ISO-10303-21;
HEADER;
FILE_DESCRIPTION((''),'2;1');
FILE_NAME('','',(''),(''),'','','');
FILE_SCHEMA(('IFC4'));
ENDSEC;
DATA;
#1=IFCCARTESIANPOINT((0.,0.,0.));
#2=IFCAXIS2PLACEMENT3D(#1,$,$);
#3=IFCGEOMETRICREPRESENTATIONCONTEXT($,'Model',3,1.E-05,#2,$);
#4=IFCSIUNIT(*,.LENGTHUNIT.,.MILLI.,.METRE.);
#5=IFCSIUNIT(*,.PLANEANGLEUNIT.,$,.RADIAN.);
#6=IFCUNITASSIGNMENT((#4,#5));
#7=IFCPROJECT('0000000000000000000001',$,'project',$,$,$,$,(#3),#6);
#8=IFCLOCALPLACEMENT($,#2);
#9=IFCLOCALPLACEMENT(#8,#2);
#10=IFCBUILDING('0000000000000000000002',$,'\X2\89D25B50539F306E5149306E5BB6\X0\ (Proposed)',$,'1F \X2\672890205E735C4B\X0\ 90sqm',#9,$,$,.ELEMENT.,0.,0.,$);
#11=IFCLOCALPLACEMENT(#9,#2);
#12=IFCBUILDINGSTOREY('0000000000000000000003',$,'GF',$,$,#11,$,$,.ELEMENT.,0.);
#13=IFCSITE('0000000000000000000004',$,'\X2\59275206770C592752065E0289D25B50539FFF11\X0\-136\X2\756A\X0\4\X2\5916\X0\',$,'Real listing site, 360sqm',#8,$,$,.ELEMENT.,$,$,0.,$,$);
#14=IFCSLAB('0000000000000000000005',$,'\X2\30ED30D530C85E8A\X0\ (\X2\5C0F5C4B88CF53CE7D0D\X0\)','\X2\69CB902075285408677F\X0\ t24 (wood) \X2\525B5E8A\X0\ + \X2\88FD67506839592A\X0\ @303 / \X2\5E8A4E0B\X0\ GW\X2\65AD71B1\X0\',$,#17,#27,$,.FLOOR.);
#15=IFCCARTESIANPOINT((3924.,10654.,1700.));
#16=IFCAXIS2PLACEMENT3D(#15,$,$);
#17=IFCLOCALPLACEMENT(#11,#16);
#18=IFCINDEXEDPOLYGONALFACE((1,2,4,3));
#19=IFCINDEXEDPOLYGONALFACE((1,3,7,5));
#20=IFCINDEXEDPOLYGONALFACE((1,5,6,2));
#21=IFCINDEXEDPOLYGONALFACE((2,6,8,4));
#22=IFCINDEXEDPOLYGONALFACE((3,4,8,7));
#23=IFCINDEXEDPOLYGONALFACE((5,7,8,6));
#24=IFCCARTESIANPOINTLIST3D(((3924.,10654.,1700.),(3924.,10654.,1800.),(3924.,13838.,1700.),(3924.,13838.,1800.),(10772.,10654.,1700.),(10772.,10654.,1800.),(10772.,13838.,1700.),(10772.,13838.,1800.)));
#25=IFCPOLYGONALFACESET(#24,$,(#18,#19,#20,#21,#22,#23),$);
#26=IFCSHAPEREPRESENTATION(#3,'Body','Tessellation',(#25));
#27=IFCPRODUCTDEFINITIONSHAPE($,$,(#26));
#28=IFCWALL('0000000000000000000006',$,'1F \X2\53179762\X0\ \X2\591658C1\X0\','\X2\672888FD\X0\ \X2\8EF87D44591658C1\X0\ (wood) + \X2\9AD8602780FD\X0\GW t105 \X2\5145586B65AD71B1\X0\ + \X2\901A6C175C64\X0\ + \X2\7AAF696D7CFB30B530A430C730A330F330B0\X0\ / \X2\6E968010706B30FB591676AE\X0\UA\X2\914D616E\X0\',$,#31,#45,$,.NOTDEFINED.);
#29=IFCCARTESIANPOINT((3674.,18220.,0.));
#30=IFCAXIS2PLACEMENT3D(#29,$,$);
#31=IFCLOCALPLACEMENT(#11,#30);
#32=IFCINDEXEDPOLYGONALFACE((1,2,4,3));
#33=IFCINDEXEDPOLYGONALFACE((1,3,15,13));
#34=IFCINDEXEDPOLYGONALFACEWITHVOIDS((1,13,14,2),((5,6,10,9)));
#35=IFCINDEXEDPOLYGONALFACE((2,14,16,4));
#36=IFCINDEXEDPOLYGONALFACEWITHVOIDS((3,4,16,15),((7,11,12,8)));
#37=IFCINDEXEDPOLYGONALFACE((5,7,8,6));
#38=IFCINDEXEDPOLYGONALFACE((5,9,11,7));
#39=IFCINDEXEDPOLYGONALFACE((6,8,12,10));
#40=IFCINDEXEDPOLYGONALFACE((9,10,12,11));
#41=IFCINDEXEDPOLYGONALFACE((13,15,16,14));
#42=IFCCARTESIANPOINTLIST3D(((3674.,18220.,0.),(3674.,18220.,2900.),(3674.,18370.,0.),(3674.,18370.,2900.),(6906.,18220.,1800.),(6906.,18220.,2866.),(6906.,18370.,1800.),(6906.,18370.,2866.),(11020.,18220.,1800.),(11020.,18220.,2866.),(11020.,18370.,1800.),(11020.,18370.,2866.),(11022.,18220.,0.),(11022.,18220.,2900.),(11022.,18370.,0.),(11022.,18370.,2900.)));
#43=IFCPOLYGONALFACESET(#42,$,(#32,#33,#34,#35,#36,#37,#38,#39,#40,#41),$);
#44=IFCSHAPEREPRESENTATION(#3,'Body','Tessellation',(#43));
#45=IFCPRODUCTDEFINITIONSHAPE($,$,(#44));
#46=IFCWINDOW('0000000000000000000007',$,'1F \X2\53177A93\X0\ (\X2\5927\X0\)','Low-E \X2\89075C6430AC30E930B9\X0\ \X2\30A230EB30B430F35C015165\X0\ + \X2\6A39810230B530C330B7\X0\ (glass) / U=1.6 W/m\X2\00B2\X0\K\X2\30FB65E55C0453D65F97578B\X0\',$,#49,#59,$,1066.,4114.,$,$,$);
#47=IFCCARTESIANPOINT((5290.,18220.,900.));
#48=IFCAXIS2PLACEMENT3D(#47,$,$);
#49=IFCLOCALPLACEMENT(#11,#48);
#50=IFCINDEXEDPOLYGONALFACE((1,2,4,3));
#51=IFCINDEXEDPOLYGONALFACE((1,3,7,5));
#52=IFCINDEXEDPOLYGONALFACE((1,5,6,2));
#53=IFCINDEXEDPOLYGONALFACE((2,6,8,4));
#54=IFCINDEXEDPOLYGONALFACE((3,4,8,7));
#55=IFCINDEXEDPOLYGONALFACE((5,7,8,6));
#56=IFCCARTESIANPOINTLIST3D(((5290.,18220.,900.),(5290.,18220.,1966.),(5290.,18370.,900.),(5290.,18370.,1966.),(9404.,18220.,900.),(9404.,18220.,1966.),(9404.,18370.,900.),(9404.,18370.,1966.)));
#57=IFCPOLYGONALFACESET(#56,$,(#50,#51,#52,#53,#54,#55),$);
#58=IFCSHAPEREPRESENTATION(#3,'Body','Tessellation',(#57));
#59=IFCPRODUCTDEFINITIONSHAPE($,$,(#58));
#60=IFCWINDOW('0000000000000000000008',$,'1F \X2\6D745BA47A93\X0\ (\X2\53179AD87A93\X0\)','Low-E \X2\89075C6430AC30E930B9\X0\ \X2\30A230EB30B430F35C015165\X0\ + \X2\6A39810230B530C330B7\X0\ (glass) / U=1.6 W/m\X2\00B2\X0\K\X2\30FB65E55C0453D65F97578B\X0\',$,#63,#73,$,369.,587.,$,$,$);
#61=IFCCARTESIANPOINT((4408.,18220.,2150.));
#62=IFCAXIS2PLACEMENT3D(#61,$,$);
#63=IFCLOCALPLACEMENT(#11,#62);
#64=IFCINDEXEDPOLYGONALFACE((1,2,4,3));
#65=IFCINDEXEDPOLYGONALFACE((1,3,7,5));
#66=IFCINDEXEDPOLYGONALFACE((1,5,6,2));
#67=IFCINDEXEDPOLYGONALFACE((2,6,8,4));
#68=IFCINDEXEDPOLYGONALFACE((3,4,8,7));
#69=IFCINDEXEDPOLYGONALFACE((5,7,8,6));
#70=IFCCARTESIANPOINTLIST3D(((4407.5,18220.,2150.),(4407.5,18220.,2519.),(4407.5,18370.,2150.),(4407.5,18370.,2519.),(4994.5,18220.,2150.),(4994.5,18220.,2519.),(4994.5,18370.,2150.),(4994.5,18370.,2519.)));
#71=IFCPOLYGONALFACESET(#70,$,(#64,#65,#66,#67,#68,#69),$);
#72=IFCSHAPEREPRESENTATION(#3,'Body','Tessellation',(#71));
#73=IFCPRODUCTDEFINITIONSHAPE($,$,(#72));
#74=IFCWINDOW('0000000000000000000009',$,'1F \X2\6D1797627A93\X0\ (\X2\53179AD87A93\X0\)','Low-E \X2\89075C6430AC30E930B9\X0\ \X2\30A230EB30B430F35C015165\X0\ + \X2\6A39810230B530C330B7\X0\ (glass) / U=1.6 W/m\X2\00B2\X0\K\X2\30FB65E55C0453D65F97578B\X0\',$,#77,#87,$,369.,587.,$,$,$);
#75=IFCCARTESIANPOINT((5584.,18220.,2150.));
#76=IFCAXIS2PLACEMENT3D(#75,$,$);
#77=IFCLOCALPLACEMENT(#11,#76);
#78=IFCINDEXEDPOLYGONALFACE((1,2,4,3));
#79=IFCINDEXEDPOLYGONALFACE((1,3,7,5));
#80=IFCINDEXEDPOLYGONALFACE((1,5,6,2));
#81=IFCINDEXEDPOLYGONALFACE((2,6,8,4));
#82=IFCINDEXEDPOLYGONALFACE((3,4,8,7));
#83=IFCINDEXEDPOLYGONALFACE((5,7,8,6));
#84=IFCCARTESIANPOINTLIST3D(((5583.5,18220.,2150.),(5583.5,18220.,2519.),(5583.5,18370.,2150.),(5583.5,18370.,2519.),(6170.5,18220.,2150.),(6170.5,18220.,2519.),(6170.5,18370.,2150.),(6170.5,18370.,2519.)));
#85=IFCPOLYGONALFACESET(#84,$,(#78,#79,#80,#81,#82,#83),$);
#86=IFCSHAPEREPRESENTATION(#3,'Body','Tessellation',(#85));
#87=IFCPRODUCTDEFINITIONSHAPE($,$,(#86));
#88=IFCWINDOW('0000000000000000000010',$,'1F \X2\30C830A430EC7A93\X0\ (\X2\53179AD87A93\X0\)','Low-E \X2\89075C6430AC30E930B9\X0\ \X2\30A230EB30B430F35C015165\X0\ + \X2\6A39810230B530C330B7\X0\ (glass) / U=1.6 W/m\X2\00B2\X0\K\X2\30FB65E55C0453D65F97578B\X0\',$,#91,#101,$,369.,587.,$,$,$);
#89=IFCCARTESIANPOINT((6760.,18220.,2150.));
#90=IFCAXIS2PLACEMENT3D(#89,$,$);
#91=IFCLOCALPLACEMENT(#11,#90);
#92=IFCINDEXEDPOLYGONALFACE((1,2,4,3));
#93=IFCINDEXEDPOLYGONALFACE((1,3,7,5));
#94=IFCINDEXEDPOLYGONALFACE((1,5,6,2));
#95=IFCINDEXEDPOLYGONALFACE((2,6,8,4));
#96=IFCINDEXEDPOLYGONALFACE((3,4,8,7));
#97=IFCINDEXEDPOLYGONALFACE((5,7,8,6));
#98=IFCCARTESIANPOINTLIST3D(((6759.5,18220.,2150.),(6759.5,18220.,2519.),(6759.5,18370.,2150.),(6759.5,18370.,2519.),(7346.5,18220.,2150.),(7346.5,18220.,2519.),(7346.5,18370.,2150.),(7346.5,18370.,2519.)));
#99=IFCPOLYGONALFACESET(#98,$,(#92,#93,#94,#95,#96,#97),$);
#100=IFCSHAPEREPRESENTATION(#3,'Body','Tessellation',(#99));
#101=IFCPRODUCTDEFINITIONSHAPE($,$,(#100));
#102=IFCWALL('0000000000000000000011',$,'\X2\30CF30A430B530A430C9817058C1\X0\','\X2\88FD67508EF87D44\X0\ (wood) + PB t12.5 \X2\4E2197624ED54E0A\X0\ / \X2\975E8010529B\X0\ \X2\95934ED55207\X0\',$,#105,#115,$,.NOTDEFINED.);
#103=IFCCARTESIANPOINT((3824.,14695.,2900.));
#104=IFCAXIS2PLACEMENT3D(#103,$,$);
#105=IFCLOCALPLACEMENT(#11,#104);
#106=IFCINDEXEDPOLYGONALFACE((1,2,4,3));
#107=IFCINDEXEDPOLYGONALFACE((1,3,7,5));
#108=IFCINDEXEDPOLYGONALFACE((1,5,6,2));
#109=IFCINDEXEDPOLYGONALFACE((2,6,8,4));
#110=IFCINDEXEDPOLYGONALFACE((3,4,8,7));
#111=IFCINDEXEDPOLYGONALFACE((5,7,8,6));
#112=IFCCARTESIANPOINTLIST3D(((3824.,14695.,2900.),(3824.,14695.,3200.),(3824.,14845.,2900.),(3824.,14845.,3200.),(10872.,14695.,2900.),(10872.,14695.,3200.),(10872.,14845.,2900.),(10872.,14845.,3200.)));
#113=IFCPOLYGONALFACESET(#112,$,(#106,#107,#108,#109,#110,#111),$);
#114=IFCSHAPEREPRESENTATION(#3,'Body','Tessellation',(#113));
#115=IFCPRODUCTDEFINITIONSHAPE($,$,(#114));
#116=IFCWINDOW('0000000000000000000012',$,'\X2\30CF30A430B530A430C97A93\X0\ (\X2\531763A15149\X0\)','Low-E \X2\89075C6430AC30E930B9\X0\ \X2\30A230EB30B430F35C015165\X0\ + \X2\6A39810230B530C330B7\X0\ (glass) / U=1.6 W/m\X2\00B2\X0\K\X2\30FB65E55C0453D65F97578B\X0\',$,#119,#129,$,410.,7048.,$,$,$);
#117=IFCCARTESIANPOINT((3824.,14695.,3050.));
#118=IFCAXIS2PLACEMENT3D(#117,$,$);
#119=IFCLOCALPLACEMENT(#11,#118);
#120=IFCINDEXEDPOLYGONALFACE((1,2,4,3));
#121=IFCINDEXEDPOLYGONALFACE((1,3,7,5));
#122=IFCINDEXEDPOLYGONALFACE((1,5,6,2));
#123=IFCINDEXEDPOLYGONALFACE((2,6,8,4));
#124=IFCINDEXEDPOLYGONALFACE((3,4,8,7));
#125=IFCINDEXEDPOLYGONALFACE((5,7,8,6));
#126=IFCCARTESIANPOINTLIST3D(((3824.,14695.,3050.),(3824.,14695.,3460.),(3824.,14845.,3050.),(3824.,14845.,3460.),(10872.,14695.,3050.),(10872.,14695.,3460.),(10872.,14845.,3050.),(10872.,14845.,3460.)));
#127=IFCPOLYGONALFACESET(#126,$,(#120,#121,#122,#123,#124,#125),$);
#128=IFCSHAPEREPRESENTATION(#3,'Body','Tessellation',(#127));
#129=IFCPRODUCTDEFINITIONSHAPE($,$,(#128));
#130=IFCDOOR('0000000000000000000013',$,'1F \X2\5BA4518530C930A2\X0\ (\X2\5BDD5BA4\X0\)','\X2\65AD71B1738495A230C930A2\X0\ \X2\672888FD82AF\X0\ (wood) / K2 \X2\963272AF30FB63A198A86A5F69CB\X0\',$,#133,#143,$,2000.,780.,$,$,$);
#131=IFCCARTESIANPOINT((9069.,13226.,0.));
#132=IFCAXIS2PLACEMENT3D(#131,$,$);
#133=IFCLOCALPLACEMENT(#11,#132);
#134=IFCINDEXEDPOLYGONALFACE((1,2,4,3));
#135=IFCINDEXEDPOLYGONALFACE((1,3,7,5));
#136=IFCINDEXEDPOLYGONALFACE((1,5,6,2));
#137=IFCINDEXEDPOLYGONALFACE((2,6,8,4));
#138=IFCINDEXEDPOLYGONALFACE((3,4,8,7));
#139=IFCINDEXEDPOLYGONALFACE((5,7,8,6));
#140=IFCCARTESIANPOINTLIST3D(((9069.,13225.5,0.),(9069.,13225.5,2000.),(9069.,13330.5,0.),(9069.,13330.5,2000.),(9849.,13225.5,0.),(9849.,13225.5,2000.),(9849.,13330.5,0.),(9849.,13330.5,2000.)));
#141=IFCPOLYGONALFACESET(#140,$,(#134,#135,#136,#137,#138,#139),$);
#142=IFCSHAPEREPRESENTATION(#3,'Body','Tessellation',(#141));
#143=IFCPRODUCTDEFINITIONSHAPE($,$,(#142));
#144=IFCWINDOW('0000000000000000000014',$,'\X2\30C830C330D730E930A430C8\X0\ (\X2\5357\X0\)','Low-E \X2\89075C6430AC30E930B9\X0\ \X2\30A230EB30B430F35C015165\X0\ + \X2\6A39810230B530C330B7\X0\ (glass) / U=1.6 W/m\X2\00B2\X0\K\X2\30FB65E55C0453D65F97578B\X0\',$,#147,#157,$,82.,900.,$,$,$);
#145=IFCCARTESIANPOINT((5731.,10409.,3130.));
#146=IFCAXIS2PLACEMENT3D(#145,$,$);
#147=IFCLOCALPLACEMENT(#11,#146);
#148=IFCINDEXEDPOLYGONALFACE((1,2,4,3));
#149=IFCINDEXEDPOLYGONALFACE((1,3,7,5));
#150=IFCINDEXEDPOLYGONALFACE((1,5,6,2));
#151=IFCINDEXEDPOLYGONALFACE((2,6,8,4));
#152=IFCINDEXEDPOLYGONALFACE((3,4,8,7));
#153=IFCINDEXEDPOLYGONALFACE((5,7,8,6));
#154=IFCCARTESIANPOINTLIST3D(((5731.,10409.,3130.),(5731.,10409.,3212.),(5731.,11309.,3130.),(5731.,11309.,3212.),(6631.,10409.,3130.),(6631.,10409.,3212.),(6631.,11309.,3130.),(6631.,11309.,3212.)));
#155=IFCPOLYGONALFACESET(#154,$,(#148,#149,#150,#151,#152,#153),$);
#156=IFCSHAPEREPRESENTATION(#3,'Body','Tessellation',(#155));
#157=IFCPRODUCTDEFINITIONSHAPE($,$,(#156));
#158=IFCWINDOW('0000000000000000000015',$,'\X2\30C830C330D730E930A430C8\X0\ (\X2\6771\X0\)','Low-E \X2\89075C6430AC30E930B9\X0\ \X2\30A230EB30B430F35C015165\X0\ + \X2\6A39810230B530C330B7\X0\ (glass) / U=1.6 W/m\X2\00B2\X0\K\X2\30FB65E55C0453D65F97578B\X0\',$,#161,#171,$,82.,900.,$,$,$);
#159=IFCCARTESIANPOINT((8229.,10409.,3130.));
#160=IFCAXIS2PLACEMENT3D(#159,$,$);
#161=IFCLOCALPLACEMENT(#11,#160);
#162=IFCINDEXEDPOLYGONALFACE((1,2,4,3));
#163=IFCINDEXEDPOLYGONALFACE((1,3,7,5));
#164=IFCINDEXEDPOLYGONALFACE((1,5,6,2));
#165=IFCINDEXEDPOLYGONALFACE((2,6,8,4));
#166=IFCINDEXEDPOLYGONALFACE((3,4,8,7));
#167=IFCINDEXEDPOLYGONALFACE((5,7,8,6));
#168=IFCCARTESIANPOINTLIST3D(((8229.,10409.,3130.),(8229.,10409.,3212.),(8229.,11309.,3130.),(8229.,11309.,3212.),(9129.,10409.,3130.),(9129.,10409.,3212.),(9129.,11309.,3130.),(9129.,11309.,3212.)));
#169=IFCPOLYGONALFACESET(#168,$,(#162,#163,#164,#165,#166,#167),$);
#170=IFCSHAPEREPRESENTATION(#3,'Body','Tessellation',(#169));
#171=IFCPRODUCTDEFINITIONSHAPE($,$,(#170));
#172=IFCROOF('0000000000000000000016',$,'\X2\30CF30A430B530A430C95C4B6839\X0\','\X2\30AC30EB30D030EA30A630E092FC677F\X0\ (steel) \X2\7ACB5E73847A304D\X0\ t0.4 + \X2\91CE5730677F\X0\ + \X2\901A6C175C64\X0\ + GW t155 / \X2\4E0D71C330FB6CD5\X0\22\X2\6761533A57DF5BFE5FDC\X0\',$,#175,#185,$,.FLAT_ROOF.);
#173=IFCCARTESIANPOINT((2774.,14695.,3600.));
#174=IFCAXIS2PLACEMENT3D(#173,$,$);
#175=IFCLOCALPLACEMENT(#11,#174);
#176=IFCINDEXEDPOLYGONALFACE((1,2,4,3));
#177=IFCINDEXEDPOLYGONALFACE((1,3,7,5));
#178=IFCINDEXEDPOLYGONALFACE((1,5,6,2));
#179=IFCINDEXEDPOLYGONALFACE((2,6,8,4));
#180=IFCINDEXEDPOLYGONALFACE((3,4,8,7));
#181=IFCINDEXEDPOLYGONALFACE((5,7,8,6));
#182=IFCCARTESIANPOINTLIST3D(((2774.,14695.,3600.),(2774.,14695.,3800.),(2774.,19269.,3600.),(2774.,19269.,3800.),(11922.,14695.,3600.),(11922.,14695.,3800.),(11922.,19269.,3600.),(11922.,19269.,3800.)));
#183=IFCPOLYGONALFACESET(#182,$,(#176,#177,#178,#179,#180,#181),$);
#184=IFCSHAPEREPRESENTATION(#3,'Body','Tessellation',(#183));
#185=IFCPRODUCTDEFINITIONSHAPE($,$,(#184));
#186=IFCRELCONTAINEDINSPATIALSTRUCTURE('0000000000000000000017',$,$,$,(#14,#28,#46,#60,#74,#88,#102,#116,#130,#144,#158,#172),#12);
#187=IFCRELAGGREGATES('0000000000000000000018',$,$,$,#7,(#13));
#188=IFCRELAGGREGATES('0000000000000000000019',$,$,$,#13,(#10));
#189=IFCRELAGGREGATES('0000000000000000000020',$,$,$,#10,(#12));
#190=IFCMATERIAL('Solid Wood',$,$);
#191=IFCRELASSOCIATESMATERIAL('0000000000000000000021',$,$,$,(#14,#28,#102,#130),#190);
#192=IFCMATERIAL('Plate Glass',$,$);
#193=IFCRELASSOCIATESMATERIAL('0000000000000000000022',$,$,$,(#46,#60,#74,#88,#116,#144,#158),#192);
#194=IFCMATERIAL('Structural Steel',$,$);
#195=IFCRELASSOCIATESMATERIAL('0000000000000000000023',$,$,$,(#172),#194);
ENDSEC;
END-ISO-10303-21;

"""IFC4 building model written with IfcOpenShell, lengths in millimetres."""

from ifc_helpers import new_model, si_unit, frame, frame_2d, origin, place, context, project, spatial, rectangle, extrude, material, element, fill, save


model = new_model("IFC4")

# Units and contexts
model_context = context("Model", 3, precision=1e-05, world=origin())
ifc_project = project(units=[si_unit("LENGTHUNIT", "METRE", prefix="MILLI"), si_unit("PLANEANGLEUNIT", "RADIAN")], contexts=[model_context])

# Site, building, storey
site_placement = place(None, origin())
site = spatial("IfcSite", under=ifc_project, at=site_placement, Name="大分県大分市角子原１-136番4外", ObjectType="Real listing site, 360sqm", CompositionType="ELEMENT", RefElevation=0.0)
building_placement = place(site_placement, origin())
building = spatial("IfcBuilding", under=site, at=building_placement, Name="角子原の光の家 (Proposed)", ObjectType="1F 木造平屋 90sqm", CompositionType="ELEMENT", ElevationOfRefHeight=0.0, ElevationOfTerrain=0.0)
storey_placement = place(building_placement, origin())
storey = spatial("IfcBuildingStorey", under=building, at=storey_placement, Name="GF", CompositionType="ELEMENT", Elevation=0.0)

# Slab
ifc_material_1 = material(Name="Solid Wood")
slab_placement = place(storey_placement, frame((3924.0, 10654.0, 1700.0)))
element("IfcSlab", 1, at=slab_placement, inside=storey, material=ifc_material_1, Name="ロフト床 (小屋裏収納)", Description="構造用合板 t24 (wood) 剛床 + 製材根太 @303 / 床下 GW断熱", PredefinedType="FLOOR", context=model_context, shape_type="SweptSolid", body=[
    extrude(rectangle(XDim=6848.0, YDim=3184.0, at=frame_2d((3424.0, 1592.0))), frame((3924.0, 10654.0, 1700.0)), (0.0, 0.0, 1.0), 100.0),
])

# Wall, openings, windows
wall_1_placement = place(storey_placement, frame((3674.0, 18220.0, 0.0)))
wall_1 = element("IfcWall", 2, at=wall_1_placement, inside=storey, material=ifc_material_1, Name="1F 北面 外壁", Description="木製 軸組外壁 (wood) + 高性能GW t105 充填断熱 + 通気層 + 窯業系サイディング / 準耐火・外皮UA配慮", PredefinedType="NOTDEFINED", context=model_context, shape_type="SweptSolid", body=[
    extrude(rectangle(XDim=7348.0, YDim=150.0, at=frame_2d((3674.0, 75.0))), frame((3674.0, 18220.0, 0.0)), (0.0, 0.0, 1.0), 2900.0),
])
opening_1_placement = place(storey_placement, frame((5290.0, 18220.0, 900.0)))
opening_1 = element("IfcOpeningElement", 3, at=opening_1_placement, cuts=wall_1, PredefinedType="NOTDEFINED", context=model_context, shape_type="SweptSolid", body=[
    extrude(rectangle(XDim=4114.0, YDim=150.0, at=frame_2d((2057.0, 75.0))), frame((5290.0, 18220.0, 900.0)), (0.0, 0.0, 1.0), 1066.0),
])
opening_2_placement = place(storey_placement, frame((4408.0, 18220.0, 2150.0)))
opening_2 = element("IfcOpeningElement", 4, at=opening_2_placement, cuts=wall_1, PredefinedType="NOTDEFINED", context=model_context, shape_type="SweptSolid", body=[
    extrude(rectangle(XDim=587.0, YDim=150.0, at=frame_2d((293.0, 75.0))), frame((4408.0, 18220.0, 2150.0)), (0.0, 0.0, 1.0), 369.0),
])
opening_3_placement = place(storey_placement, frame((5584.0, 18220.0, 2150.0)))
opening_3 = element("IfcOpeningElement", 5, at=opening_3_placement, cuts=wall_1, PredefinedType="NOTDEFINED", context=model_context, shape_type="SweptSolid", body=[
    extrude(rectangle(XDim=587.0, YDim=150.0, at=frame_2d((293.0, 75.0))), frame((5584.0, 18220.0, 2150.0)), (0.0, 0.0, 1.0), 369.0),
])
opening_4_placement = place(storey_placement, frame((6760.0, 18220.0, 2150.0)))
opening_4 = element("IfcOpeningElement", 6, at=opening_4_placement, cuts=wall_1, PredefinedType="NOTDEFINED", context=model_context, shape_type="SweptSolid", body=[
    extrude(rectangle(XDim=587.0, YDim=150.0, at=frame_2d((293.0, 75.0))), frame((6760.0, 18220.0, 2150.0)), (0.0, 0.0, 1.0), 369.0),
])
ifc_material_2 = material(Name="Plate Glass")
window_1_placement = place(storey_placement, frame((5290.0, 18220.0, 900.0)))
window_1 = element("IfcWindow", 7, at=window_1_placement, inside=storey, material=ifc_material_2, Name="1F 北窓 (大)", Description="Low-E 複層ガラス アルゴン封入 + 樹脂サッシ (glass) / U=1.6 W/m²K・日射取得型", OverallHeight=1066.0, OverallWidth=4114.0, context=model_context, shape_type="SweptSolid", body=[
    extrude(rectangle(XDim=4114.0, YDim=150.0, at=frame_2d((2057.0, 75.0))), frame((5290.0, 18220.0, 900.0)), (0.0, 0.0, 1.0), 1066.0),
])
fill(opening_1, window_1)
window_2_placement = place(storey_placement, frame((4408.0, 18220.0, 2150.0)))
window_2 = element("IfcWindow", 8, at=window_2_placement, inside=storey, material=ifc_material_2, Name="1F 浴室窓 (北高窓)", Description="Low-E 複層ガラス アルゴン封入 + 樹脂サッシ (glass) / U=1.6 W/m²K・日射取得型", OverallHeight=369.0, OverallWidth=587.0, context=model_context, shape_type="SweptSolid", body=[
    extrude(rectangle(XDim=587.0, YDim=150.0, at=frame_2d((293.0, 75.0))), frame((4408.0, 18220.0, 2150.0)), (0.0, 0.0, 1.0), 369.0),
])
fill(opening_2, window_2)
window_3_placement = place(storey_placement, frame((5584.0, 18220.0, 2150.0)))
window_3 = element("IfcWindow", 9, at=window_3_placement, inside=storey, material=ifc_material_2, Name="1F 洗面窓 (北高窓)", Description="Low-E 複層ガラス アルゴン封入 + 樹脂サッシ (glass) / U=1.6 W/m²K・日射取得型", OverallHeight=369.0, OverallWidth=587.0, context=model_context, shape_type="SweptSolid", body=[
    extrude(rectangle(XDim=587.0, YDim=150.0, at=frame_2d((293.0, 75.0))), frame((5584.0, 18220.0, 2150.0)), (0.0, 0.0, 1.0), 369.0),
])
fill(opening_3, window_3)
window_4_placement = place(storey_placement, frame((6760.0, 18220.0, 2150.0)))
window_4 = element("IfcWindow", 10, at=window_4_placement, inside=storey, material=ifc_material_2, Name="1F トイレ窓 (北高窓)", Description="Low-E 複層ガラス アルゴン封入 + 樹脂サッシ (glass) / U=1.6 W/m²K・日射取得型", OverallHeight=369.0, OverallWidth=587.0, context=model_context, shape_type="SweptSolid", body=[
    extrude(rectangle(XDim=587.0, YDim=150.0, at=frame_2d((293.0, 75.0))), frame((6760.0, 18220.0, 2150.0)), (0.0, 0.0, 1.0), 369.0),
])
fill(opening_4, window_4)

# Wall, opening, window
wall_2_placement = place(storey_placement, frame((3824.0, 14695.0, 2900.0)))
wall_2 = element("IfcWall", 11, at=wall_2_placement, inside=storey, material=ifc_material_1, Name="ハイサイド腰壁", Description="製材軸組 (wood) + PB t12.5 両面仕上 / 非耐力 間仕切", PredefinedType="NOTDEFINED", context=model_context, shape_type="SweptSolid", body=[
    extrude(rectangle(XDim=7048.0, YDim=150.0, at=frame_2d((3524.0, 75.0))), frame((3824.0, 14695.0, 2900.0)), (0.0, 0.0, 1.0), 700.0),
])
opening_5_placement = place(storey_placement, frame((3824.0, 14695.0, 3050.0)))
opening_5 = element("IfcOpeningElement", 12, at=opening_5_placement, cuts=wall_2, PredefinedType="NOTDEFINED", context=model_context, shape_type="SweptSolid", body=[
    extrude(rectangle(XDim=7048.0, YDim=150.0, at=frame_2d((3524.0, 75.0))), frame((3824.0, 14695.0, 3050.0)), (0.0, 0.0, 1.0), 410.0),
])
window_5_placement = place(storey_placement, frame((3824.0, 14695.0, 3050.0)))
window_5 = element("IfcWindow", 13, at=window_5_placement, inside=storey, material=ifc_material_2, Name="ハイサイド窓 (北採光)", Description="Low-E 複層ガラス アルゴン封入 + 樹脂サッシ (glass) / U=1.6 W/m²K・日射取得型", OverallHeight=410.0, OverallWidth=7048.0, context=model_context, shape_type="SweptSolid", body=[
    extrude(rectangle(XDim=7048.0, YDim=150.0, at=frame_2d((3524.0, 75.0))), frame((3824.0, 14695.0, 3050.0)), (0.0, 0.0, 1.0), 410.0),
])
fill(opening_5, window_5)

# Door
door_1_placement = place(storey_placement, frame((9069.0, 13226.0, 0.0)))
element("IfcDoor", 14, at=door_1_placement, inside=storey, material=ifc_material_1, Name="1F 室内ドア (寝室)", Description="断熱玄関ドア 木製芯 (wood) / K2 防犯・採風機構", OverallHeight=2000.0, OverallWidth=780.0, context=model_context, shape_type="SweptSolid", body=[
    extrude(rectangle(XDim=780.0, YDim=105.0, at=frame_2d((390.0, 52.0))), frame((9069.0, 13226.0, 0.0)), (0.0, 0.0, 1.0), 2000.0),
])

# Windows
window_6_placement = place(storey_placement, frame((5731.0, 10409.0, 3130.0)))
element("IfcWindow", 15, at=window_6_placement, inside=storey, material=ifc_material_2, Name="トップライト (南)", Description="Low-E 複層ガラス アルゴン封入 + 樹脂サッシ (glass) / U=1.6 W/m²K・日射取得型", OverallHeight=82.0, OverallWidth=900.0, context=model_context, shape_type="SweptSolid", body=[
    extrude(rectangle(XDim=900.0, YDim=900.0, at=frame_2d((450.0, 450.0))), frame((5731.0, 10409.0, 3130.0)), (0.0, 0.0, 1.0), 82.0),
])
window_7_placement = place(storey_placement, frame((8229.0, 10409.0, 3130.0)))
element("IfcWindow", 16, at=window_7_placement, inside=storey, material=ifc_material_2, Name="トップライト (東)", Description="Low-E 複層ガラス アルゴン封入 + 樹脂サッシ (glass) / U=1.6 W/m²K・日射取得型", OverallHeight=82.0, OverallWidth=900.0, context=model_context, shape_type="SweptSolid", body=[
    extrude(rectangle(XDim=900.0, YDim=900.0, at=frame_2d((450.0, 450.0))), frame((8229.0, 10409.0, 3130.0)), (0.0, 0.0, 1.0), 82.0),
])

# Roof
ifc_material_3 = material(Name="Structural Steel")
roof_placement = place(storey_placement, frame((2774.0, 14695.0, 3600.0)))
element("IfcRoof", 17, at=roof_placement, inside=storey, material=ifc_material_3, Name="ハイサイド屋根", Description="ガルバリウム鋼板 (steel) 立平葺き t0.4 + 野地板 + 通気層 + GW t155 / 不燃・法22条区域対応", PredefinedType="FLAT_ROOF", context=model_context, shape_type="SweptSolid", body=[
    extrude(rectangle(XDim=9148.0, YDim=4574.0, at=frame_2d((4574.0, 2287.0))), frame((2774.0, 14695.0, 3600.0)), (0.0, 0.0, 1.0), 200.0),
])

save(model, "model.ifc")
